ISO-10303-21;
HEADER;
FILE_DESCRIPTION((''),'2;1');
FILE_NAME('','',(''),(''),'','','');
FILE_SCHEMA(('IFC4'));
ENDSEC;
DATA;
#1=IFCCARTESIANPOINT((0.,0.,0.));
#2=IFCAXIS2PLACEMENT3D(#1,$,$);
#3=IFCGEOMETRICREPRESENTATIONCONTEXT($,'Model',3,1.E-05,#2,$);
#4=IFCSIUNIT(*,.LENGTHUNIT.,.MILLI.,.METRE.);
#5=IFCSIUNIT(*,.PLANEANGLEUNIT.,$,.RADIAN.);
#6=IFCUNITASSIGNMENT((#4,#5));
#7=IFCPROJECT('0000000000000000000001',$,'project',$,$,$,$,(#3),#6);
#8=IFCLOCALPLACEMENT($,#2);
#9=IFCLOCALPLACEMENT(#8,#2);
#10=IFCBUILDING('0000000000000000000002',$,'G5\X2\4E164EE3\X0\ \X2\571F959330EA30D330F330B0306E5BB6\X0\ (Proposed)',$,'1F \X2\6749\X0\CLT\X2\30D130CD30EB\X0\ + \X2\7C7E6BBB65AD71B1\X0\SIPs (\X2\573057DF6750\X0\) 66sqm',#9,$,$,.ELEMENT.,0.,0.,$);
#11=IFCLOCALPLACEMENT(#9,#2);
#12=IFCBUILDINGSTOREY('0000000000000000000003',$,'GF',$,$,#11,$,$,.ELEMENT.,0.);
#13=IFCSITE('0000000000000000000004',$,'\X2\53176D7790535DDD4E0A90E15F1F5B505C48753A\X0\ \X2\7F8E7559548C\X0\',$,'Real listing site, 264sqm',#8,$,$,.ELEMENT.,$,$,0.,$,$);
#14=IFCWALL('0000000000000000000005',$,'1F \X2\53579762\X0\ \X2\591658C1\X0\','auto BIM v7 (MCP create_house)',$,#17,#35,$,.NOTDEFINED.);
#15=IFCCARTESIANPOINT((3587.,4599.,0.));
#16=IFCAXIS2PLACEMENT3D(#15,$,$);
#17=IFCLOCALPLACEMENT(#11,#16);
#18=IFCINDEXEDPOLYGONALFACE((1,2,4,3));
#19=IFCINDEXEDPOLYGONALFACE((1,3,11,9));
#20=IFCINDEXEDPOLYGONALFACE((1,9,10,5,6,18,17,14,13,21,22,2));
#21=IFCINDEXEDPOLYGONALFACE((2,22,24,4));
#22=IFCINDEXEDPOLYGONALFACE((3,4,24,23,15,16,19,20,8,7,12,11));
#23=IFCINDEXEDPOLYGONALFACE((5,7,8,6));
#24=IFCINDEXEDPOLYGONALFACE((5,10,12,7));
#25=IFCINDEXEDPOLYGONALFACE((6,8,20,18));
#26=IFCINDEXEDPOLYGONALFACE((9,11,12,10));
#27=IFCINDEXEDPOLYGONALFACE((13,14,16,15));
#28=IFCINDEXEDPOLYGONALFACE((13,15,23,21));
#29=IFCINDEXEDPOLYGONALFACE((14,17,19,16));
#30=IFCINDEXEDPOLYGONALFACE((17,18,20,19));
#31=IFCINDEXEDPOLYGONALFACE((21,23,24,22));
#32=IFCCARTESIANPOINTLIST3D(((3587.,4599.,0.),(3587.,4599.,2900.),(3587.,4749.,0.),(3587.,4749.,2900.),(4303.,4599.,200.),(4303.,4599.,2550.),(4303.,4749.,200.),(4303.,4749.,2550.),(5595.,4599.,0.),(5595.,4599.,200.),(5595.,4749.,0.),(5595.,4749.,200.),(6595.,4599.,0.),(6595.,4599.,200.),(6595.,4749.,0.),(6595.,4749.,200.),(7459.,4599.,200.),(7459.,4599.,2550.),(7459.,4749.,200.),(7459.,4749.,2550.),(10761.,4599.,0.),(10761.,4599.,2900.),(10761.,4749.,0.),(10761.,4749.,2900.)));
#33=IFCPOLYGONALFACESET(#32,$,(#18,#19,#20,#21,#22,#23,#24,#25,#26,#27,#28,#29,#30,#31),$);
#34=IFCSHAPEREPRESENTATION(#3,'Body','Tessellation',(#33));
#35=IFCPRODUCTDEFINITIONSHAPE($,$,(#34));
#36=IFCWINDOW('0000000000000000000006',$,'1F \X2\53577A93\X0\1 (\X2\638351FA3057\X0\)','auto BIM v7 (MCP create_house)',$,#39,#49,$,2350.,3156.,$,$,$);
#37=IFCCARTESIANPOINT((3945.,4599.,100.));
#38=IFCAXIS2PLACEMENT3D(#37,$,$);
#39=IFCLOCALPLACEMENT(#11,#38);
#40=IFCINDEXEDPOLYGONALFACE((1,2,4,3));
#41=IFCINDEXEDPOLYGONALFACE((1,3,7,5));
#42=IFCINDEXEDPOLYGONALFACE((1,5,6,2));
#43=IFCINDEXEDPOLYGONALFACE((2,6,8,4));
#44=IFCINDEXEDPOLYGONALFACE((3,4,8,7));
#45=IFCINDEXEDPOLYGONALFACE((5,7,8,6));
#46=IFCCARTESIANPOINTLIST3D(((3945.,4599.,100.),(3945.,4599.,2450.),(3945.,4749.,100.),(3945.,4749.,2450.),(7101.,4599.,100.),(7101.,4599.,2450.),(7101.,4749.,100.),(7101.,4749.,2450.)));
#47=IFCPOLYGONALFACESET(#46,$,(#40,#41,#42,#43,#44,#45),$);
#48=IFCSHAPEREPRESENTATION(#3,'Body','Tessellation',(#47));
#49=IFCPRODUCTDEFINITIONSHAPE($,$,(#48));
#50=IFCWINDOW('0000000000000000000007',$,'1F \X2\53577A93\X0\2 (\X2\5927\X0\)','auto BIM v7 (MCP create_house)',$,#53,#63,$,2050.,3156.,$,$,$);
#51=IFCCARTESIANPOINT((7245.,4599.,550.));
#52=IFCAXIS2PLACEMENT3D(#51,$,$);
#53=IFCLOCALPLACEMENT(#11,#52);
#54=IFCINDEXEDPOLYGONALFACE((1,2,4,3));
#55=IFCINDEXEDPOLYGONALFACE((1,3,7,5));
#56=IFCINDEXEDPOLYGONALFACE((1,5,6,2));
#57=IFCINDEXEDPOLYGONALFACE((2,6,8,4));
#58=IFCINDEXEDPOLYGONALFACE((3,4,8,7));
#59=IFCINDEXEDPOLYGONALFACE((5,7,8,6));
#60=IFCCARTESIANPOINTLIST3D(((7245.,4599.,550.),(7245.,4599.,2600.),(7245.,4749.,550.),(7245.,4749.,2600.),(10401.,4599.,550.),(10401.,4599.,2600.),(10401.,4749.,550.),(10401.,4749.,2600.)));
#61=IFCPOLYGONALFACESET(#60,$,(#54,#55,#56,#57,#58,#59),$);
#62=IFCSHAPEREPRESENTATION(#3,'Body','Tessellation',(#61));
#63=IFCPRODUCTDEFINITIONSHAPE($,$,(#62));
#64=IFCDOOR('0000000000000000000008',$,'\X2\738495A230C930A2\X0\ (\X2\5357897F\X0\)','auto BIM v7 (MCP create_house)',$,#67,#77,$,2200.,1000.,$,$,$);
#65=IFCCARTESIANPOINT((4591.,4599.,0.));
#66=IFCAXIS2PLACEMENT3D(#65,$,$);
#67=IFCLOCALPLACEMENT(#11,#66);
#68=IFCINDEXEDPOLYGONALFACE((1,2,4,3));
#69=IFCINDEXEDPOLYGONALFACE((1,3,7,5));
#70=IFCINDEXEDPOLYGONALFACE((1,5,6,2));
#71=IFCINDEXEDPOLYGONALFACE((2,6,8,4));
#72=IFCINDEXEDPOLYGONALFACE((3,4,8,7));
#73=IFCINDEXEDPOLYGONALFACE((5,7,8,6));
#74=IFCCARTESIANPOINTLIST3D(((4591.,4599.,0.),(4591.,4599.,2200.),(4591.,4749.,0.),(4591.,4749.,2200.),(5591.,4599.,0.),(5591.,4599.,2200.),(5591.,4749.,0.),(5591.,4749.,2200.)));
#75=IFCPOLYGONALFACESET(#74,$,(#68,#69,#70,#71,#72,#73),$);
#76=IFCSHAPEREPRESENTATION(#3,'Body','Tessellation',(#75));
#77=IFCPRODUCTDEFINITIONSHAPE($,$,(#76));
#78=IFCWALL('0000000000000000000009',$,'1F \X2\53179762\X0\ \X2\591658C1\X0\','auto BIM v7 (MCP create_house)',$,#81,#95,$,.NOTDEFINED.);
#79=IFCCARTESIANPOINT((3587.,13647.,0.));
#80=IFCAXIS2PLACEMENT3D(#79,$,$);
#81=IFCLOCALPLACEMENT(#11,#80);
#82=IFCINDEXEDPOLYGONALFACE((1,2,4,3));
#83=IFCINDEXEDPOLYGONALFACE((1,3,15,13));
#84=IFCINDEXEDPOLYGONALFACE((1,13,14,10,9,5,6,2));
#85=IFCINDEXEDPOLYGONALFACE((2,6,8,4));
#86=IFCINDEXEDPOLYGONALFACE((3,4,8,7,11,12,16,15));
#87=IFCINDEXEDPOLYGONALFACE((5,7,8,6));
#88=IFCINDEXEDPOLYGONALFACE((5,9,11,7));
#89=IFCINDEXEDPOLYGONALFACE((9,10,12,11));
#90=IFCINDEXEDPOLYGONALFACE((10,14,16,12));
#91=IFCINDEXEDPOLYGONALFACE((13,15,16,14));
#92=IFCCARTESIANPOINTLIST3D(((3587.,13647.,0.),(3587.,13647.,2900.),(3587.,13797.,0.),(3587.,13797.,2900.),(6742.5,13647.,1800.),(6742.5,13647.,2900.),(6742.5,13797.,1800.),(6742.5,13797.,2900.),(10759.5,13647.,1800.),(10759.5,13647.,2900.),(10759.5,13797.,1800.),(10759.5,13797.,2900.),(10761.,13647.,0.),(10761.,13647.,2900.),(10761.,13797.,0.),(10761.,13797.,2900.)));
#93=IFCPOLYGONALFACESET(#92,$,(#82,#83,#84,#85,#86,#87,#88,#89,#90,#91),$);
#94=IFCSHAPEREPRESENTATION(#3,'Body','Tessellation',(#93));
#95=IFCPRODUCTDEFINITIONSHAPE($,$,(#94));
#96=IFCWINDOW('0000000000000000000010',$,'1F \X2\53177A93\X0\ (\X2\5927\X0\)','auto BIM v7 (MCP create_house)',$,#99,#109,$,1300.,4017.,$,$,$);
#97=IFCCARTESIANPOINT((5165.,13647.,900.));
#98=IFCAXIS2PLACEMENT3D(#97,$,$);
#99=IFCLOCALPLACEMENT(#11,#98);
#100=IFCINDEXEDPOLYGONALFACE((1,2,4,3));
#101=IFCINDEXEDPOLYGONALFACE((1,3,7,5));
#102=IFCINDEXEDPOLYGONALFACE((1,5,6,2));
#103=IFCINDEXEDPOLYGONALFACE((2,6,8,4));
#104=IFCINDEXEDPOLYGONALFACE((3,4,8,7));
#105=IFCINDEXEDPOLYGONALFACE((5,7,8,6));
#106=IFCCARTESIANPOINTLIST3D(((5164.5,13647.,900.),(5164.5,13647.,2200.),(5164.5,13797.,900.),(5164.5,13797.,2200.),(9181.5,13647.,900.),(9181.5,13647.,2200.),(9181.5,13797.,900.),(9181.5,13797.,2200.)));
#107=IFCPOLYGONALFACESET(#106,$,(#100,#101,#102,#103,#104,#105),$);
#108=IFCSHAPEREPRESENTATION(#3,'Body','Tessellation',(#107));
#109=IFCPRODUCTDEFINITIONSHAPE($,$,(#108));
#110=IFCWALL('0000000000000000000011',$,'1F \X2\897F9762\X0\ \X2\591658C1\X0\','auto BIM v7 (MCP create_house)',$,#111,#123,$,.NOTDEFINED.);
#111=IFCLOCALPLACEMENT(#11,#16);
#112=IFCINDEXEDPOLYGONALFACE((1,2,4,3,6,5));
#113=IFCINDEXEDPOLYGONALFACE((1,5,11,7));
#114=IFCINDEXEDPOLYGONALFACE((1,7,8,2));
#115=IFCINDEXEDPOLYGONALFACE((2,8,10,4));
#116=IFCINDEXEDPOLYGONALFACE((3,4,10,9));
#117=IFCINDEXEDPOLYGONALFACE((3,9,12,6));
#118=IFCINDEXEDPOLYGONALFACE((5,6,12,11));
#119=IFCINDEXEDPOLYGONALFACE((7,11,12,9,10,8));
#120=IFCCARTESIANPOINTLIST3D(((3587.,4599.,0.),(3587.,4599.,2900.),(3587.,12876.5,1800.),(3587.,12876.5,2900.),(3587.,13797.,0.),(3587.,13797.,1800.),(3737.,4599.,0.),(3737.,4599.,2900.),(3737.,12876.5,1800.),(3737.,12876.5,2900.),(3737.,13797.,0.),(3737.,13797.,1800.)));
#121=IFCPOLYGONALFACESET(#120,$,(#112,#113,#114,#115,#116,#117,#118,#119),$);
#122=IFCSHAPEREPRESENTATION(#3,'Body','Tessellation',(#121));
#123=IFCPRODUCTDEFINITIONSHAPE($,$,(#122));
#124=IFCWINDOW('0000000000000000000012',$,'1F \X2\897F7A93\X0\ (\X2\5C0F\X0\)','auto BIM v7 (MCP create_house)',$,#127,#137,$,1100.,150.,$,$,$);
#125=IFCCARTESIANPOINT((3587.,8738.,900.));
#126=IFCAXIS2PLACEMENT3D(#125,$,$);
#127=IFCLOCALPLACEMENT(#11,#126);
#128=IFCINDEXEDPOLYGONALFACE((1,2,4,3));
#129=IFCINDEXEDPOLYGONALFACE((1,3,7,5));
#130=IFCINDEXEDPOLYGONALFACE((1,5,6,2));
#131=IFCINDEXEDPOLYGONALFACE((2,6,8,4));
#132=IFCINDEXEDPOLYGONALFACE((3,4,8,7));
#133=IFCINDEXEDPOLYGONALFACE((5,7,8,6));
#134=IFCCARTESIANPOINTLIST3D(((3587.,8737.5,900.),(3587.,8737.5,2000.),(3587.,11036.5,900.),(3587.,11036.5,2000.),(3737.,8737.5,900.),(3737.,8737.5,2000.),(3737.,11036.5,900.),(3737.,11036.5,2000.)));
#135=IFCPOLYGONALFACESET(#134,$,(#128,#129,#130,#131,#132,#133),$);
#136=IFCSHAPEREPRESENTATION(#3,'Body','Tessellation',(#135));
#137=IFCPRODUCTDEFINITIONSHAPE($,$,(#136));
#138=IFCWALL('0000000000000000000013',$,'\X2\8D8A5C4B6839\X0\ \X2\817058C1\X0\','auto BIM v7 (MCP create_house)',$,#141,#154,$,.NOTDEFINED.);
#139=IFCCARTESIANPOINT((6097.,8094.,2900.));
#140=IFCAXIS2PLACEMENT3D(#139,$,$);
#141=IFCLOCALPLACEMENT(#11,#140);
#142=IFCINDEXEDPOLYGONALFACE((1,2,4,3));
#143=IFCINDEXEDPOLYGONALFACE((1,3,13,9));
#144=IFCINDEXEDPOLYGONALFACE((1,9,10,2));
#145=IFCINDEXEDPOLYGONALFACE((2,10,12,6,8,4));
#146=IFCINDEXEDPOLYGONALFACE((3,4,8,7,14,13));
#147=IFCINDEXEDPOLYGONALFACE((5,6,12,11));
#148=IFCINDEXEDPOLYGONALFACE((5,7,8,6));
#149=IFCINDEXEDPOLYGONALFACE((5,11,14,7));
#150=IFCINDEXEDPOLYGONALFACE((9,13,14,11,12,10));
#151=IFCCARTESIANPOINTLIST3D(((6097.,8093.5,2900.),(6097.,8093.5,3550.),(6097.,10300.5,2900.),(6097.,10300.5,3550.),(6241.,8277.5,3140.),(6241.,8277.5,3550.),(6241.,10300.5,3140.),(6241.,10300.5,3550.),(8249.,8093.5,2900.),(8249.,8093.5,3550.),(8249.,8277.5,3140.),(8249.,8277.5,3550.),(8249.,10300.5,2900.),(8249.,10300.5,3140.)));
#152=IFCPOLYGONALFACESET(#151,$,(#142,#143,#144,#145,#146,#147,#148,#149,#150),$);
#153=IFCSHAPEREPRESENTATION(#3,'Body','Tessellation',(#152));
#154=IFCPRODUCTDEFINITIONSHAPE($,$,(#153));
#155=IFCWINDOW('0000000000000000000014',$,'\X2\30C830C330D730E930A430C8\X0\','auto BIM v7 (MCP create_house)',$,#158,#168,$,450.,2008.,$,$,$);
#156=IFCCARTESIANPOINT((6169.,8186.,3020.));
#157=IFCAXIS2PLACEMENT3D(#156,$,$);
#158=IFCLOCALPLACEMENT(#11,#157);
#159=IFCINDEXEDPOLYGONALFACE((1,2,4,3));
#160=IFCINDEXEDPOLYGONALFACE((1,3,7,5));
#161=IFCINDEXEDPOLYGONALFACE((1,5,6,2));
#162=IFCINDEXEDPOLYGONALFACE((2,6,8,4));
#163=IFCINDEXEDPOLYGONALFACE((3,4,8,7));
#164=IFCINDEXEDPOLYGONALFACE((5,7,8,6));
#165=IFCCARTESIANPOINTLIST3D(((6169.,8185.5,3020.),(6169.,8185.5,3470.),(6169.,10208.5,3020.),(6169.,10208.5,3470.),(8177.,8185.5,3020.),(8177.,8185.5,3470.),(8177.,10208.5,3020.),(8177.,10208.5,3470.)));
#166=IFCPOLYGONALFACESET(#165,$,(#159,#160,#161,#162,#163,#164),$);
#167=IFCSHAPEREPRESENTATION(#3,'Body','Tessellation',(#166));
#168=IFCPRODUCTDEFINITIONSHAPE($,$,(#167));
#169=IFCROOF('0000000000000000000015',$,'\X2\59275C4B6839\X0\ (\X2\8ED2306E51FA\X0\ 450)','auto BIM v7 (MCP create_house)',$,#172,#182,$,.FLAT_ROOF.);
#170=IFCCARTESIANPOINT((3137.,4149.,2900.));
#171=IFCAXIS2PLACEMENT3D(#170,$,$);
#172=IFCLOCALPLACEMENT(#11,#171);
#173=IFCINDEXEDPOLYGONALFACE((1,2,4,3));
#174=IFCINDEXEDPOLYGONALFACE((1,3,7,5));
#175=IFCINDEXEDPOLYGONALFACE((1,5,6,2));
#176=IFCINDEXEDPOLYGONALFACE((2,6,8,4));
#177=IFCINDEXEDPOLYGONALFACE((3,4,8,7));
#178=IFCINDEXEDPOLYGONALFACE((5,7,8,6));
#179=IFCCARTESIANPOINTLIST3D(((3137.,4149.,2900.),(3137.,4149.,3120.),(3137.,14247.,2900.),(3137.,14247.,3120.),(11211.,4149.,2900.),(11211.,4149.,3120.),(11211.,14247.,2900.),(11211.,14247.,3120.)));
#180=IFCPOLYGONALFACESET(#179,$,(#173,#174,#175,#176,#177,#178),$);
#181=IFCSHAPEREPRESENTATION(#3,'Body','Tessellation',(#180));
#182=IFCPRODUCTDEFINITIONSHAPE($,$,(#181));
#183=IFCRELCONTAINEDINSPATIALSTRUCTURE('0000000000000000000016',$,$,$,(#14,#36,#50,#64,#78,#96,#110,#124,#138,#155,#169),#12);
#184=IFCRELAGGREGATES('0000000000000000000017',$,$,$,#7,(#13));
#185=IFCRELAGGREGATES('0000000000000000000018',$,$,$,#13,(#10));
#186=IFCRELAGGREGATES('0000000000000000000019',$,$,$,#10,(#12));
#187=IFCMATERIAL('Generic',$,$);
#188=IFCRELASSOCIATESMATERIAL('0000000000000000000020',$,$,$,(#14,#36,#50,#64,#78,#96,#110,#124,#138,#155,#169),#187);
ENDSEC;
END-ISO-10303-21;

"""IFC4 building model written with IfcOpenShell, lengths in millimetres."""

from ifc_helpers import new_model, si_unit, frame, frame_2d, origin, place, context, project, spatial, rectangle, extrude, material, element, fill, save


model = new_model("IFC4")

# Units and contexts
model_context = context("Model", 3, precision=1e-05, world=origin())
ifc_project = project(units=[si_unit("LENGTHUNIT", "METRE", prefix="MILLI"), si_unit("PLANEANGLEUNIT", "RADIAN")], contexts=[model_context])

# Site, building, storey
site_placement = place(None, origin())
site = spatial("IfcSite", under=ifc_project, at=site_placement, Name="北海道川上郡弟子屈町 美留和", ObjectType="Real listing site, 264sqm", CompositionType="ELEMENT", RefElevation=0.0)
building_placement = place(site_placement, origin())
building = spatial("IfcBuilding", under=site, at=building_placement, Name="G5世代 土間リビングの家 (Proposed)", ObjectType="1F 杉CLTパネル + 籾殻断熱SIPs (地域材) 66sqm", CompositionType="ELEMENT", ElevationOfRefHeight=0.0, ElevationOfTerrain=0.0)
storey_placement = place(building_placement, origin())
storey = spatial("IfcBuildingStorey", under=building, at=storey_placement, Name="GF", CompositionType="ELEMENT", Elevation=0.0)

# Shared definitions
ifc_material = material(Name="Generic")

# Wall, openings, windows, door
wall_1_placement = place(storey_placement, frame((3587.0, 4599.0, 0.0)))
wall_1 = element("IfcWall", 1, at=wall_1_placement, inside=storey, material=ifc_material, Name="1F 南面 外壁", Description="auto BIM v7 (MCP create_house)", PredefinedType="NOTDEFINED", context=model_context, shape_type="SweptSolid", body=[
    extrude(rectangle(XDim=7174.0, YDim=150.0, at=frame_2d((3587.0, 75.0))), frame((3587.0, 4599.0, 0.0)), (0.0, 0.0, 1.0), 2900.0),
])
opening_1_placement = place(storey_placement, frame((3945.0, 4599.0, 100.0)))
opening_1 = element("IfcOpeningElement", 2, at=opening_1_placement, cuts=wall_1, PredefinedType="NOTDEFINED", context=model_context, shape_type="SweptSolid", body=[
    extrude(rectangle(XDim=3156.0, YDim=150.0, at=frame_2d((1578.0, 75.0))), frame((3945.0, 4599.0, 100.0)), (0.0, 0.0, 1.0), 2350.0),
])
opening_2_placement = place(storey_placement, frame((7245.0, 4599.0, 550.0)))
opening_2 = element("IfcOpeningElement", 3, at=opening_2_placement, cuts=wall_1, PredefinedType="NOTDEFINED", context=model_context, shape_type="SweptSolid", body=[
    extrude(rectangle(XDim=3156.0, YDim=150.0, at=frame_2d((1578.0, 75.0))), frame((7245.0, 4599.0, 550.0)), (0.0, 0.0, 1.0), 2050.0),
])
opening_3_placement = place(storey_placement, frame((4591.0, 4599.0, 0.0)))
opening_3 = element("IfcOpeningElement", 4, at=opening_3_placement, cuts=wall_1, PredefinedType="NOTDEFINED", context=model_context, shape_type="SweptSolid", body=[
    extrude(rectangle(XDim=1000.0, YDim=150.0, at=frame_2d((500.0, 75.0))), frame((4591.0, 4599.0, 0.0)), (0.0, 0.0, 1.0), 2200.0),
])
window_1_placement = place(storey_placement, frame((3945.0, 4599.0, 100.0)))
window_1 = element("IfcWindow", 5, at=window_1_placement, inside=storey, material=ifc_material, Name="1F 南窓1 (掃出し)", Description="auto BIM v7 (MCP create_house)", OverallHeight=2350.0, OverallWidth=3156.0, context=model_context, shape_type="SweptSolid", body=[
    extrude(rectangle(XDim=3156.0, YDim=150.0, at=frame_2d((1578.0, 75.0))), frame((3945.0, 4599.0, 100.0)), (0.0, 0.0, 1.0), 2350.0),
])
fill(opening_1, window_1)
window_2_placement = place(storey_placement, frame((7245.0, 4599.0, 550.0)))
window_2 = element("IfcWindow", 6, at=window_2_placement, inside=storey, material=ifc_material, Name="1F 南窓2 (大)", Description="auto BIM v7 (MCP create_house)", OverallHeight=2050.0, OverallWidth=3156.0, context=model_context, shape_type="SweptSolid", body=[
    extrude(rectangle(XDim=3156.0, YDim=150.0, at=frame_2d((1578.0, 75.0))), frame((7245.0, 4599.0, 550.0)), (0.0, 0.0, 1.0), 2050.0),
])
fill(opening_2, window_2)
door_placement = place(storey_placement, frame((4591.0, 4599.0, 0.0)))
door = element("IfcDoor", 7, at=door_placement, inside=storey, material=ifc_material, Name="玄関ドア (南西)", Description="auto BIM v7 (MCP create_house)", OverallHeight=2200.0, OverallWidth=1000.0, context=model_context, shape_type="SweptSolid", body=[
    extrude(rectangle(XDim=1000.0, YDim=150.0, at=frame_2d((500.0, 75.0))), frame((4591.0, 4599.0, 0.0)), (0.0, 0.0, 1.0), 2200.0),
])
fill(opening_3, door)

# Walls, openings, windows
wall_2_placement = place(storey_placement, frame((3587.0, 13647.0, 0.0)))
wall_2 = element("IfcWall", 8, at=wall_2_placement, inside=storey, material=ifc_material, Name="1F 北面 外壁", Description="auto BIM v7 (MCP create_house)", PredefinedType="NOTDEFINED", context=model_context, shape_type="SweptSolid", body=[
    extrude(rectangle(XDim=7174.0, YDim=150.0, at=frame_2d((3587.0, 75.0))), frame((3587.0, 13647.0, 0.0)), (0.0, 0.0, 1.0), 2900.0),
])
opening_4_placement = place(storey_placement, frame((5165.0, 13647.0, 900.0)))
opening_4 = element("IfcOpeningElement", 9, at=opening_4_placement, cuts=wall_2, PredefinedType="NOTDEFINED", context=model_context, shape_type="SweptSolid", body=[
    extrude(rectangle(XDim=4017.0, YDim=150.0, at=frame_2d((2008.0, 75.0))), frame((5165.0, 13647.0, 900.0)), (0.0, 0.0, 1.0), 1300.0),
])
window_3_placement = place(storey_placement, frame((5165.0, 13647.0, 900.0)))
window_3 = element("IfcWindow", 10, at=window_3_placement, inside=storey, material=ifc_material, Name="1F 北窓 (大)", Description="auto BIM v7 (MCP create_house)", OverallHeight=1300.0, OverallWidth=4017.0, context=model_context, shape_type="SweptSolid", body=[
    extrude(rectangle(XDim=4017.0, YDim=150.0, at=frame_2d((2008.0, 75.0))), frame((5165.0, 13647.0, 900.0)), (0.0, 0.0, 1.0), 1300.0),
])
fill(opening_4, window_3)
wall_3_placement = place(storey_placement, frame((3587.0, 4599.0, 0.0)))
wall_3 = element("IfcWall", 11, at=wall_3_placement, inside=storey, material=ifc_material, Name="1F 西面 外壁", Description="auto BIM v7 (MCP create_house)", PredefinedType="NOTDEFINED", context=model_context, shape_type="SweptSolid", body=[
    extrude(rectangle(XDim=150.0, YDim=9198.0, at=frame_2d((75.0, 4599.0))), frame((3587.0, 4599.0, 0.0)), (0.0, 0.0, 1.0), 2900.0),
])
opening_5_placement = place(storey_placement, frame((3587.0, 8738.0, 900.0)))
opening_5 = element("IfcOpeningElement", 12, at=opening_5_placement, cuts=wall_3, PredefinedType="NOTDEFINED", context=model_context, shape_type="SweptSolid", body=[
    extrude(rectangle(XDim=150.0, YDim=2299.0, at=frame_2d((75.0, 1149.0))), frame((3587.0, 8738.0, 900.0)), (0.0, 0.0, 1.0), 1100.0),
])
window_4_placement = place(storey_placement, frame((3587.0, 8738.0, 900.0)))
window_4 = element("IfcWindow", 13, at=window_4_placement, inside=storey, material=ifc_material, Name="1F 西窓 (小)", Description="auto BIM v7 (MCP create_house)", OverallHeight=1100.0, OverallWidth=150.0, context=model_context, shape_type="SweptSolid", body=[
    extrude(rectangle(XDim=150.0, YDim=2299.0, at=frame_2d((75.0, 1149.0))), frame((3587.0, 8738.0, 900.0)), (0.0, 0.0, 1.0), 1100.0),
])
fill(opening_5, window_4)

# Wall, opening, window
wall_4_placement = place(storey_placement, frame((6097.0, 8094.0, 2900.0)))
wall_4 = element("IfcWall", 14, at=wall_4_placement, inside=storey, material=ifc_material, Name="越屋根 腰壁", Description="auto BIM v7 (MCP create_house)", PredefinedType="NOTDEFINED", context=model_context, shape_type="SweptSolid", body=[
    extrude(rectangle(XDim=2152.0, YDim=2207.0, at=frame_2d((1076.0, 1103.0))), frame((6097.0, 8094.0, 2900.0)), (0.0, 0.0, 1.0), 650.0),
])
opening_6_placement = place(storey_placement, frame((6169.0, 8186.0, 3020.0)))
opening_6 = element("IfcOpeningElement", 15, at=opening_6_placement, cuts=wall_4, PredefinedType="NOTDEFINED", context=model_context, shape_type="SweptSolid", body=[
    extrude(rectangle(XDim=2008.0, YDim=2023.0, at=frame_2d((1004.0, 1011.0))), frame((6169.0, 8186.0, 3020.0)), (0.0, 0.0, 1.0), 450.0),
])
window_5_placement = place(storey_placement, frame((6169.0, 8186.0, 3020.0)))
window_5 = element("IfcWindow", 16, at=window_5_placement, inside=storey, material=ifc_material, Name="トップライト", Description="auto BIM v7 (MCP create_house)", OverallHeight=450.0, OverallWidth=2008.0, context=model_context, shape_type="SweptSolid", body=[
    extrude(rectangle(XDim=2008.0, YDim=2023.0, at=frame_2d((1004.0, 1011.0))), frame((6169.0, 8186.0, 3020.0)), (0.0, 0.0, 1.0), 450.0),
])
fill(opening_6, window_5)

# Roof
roof_1_placement = place(storey_placement, frame((3137.0, 4149.0, 2900.0)))
element("IfcRoof", 17, at=roof_1_placement, inside=storey, material=ifc_material, Name="大屋根 (軒の出 450)", Description="auto BIM v7 (MCP create_house)", PredefinedType="FLAT_ROOF", context=model_context, shape_type="SweptSolid", body=[
    extrude(rectangle(XDim=8074.0, YDim=10098.0, at=frame_2d((4037.0, 5049.0))), frame((3137.0, 4149.0, 2900.0)), (0.0, 0.0, 1.0), 220.0),
])

save(model, "model.ifc")
